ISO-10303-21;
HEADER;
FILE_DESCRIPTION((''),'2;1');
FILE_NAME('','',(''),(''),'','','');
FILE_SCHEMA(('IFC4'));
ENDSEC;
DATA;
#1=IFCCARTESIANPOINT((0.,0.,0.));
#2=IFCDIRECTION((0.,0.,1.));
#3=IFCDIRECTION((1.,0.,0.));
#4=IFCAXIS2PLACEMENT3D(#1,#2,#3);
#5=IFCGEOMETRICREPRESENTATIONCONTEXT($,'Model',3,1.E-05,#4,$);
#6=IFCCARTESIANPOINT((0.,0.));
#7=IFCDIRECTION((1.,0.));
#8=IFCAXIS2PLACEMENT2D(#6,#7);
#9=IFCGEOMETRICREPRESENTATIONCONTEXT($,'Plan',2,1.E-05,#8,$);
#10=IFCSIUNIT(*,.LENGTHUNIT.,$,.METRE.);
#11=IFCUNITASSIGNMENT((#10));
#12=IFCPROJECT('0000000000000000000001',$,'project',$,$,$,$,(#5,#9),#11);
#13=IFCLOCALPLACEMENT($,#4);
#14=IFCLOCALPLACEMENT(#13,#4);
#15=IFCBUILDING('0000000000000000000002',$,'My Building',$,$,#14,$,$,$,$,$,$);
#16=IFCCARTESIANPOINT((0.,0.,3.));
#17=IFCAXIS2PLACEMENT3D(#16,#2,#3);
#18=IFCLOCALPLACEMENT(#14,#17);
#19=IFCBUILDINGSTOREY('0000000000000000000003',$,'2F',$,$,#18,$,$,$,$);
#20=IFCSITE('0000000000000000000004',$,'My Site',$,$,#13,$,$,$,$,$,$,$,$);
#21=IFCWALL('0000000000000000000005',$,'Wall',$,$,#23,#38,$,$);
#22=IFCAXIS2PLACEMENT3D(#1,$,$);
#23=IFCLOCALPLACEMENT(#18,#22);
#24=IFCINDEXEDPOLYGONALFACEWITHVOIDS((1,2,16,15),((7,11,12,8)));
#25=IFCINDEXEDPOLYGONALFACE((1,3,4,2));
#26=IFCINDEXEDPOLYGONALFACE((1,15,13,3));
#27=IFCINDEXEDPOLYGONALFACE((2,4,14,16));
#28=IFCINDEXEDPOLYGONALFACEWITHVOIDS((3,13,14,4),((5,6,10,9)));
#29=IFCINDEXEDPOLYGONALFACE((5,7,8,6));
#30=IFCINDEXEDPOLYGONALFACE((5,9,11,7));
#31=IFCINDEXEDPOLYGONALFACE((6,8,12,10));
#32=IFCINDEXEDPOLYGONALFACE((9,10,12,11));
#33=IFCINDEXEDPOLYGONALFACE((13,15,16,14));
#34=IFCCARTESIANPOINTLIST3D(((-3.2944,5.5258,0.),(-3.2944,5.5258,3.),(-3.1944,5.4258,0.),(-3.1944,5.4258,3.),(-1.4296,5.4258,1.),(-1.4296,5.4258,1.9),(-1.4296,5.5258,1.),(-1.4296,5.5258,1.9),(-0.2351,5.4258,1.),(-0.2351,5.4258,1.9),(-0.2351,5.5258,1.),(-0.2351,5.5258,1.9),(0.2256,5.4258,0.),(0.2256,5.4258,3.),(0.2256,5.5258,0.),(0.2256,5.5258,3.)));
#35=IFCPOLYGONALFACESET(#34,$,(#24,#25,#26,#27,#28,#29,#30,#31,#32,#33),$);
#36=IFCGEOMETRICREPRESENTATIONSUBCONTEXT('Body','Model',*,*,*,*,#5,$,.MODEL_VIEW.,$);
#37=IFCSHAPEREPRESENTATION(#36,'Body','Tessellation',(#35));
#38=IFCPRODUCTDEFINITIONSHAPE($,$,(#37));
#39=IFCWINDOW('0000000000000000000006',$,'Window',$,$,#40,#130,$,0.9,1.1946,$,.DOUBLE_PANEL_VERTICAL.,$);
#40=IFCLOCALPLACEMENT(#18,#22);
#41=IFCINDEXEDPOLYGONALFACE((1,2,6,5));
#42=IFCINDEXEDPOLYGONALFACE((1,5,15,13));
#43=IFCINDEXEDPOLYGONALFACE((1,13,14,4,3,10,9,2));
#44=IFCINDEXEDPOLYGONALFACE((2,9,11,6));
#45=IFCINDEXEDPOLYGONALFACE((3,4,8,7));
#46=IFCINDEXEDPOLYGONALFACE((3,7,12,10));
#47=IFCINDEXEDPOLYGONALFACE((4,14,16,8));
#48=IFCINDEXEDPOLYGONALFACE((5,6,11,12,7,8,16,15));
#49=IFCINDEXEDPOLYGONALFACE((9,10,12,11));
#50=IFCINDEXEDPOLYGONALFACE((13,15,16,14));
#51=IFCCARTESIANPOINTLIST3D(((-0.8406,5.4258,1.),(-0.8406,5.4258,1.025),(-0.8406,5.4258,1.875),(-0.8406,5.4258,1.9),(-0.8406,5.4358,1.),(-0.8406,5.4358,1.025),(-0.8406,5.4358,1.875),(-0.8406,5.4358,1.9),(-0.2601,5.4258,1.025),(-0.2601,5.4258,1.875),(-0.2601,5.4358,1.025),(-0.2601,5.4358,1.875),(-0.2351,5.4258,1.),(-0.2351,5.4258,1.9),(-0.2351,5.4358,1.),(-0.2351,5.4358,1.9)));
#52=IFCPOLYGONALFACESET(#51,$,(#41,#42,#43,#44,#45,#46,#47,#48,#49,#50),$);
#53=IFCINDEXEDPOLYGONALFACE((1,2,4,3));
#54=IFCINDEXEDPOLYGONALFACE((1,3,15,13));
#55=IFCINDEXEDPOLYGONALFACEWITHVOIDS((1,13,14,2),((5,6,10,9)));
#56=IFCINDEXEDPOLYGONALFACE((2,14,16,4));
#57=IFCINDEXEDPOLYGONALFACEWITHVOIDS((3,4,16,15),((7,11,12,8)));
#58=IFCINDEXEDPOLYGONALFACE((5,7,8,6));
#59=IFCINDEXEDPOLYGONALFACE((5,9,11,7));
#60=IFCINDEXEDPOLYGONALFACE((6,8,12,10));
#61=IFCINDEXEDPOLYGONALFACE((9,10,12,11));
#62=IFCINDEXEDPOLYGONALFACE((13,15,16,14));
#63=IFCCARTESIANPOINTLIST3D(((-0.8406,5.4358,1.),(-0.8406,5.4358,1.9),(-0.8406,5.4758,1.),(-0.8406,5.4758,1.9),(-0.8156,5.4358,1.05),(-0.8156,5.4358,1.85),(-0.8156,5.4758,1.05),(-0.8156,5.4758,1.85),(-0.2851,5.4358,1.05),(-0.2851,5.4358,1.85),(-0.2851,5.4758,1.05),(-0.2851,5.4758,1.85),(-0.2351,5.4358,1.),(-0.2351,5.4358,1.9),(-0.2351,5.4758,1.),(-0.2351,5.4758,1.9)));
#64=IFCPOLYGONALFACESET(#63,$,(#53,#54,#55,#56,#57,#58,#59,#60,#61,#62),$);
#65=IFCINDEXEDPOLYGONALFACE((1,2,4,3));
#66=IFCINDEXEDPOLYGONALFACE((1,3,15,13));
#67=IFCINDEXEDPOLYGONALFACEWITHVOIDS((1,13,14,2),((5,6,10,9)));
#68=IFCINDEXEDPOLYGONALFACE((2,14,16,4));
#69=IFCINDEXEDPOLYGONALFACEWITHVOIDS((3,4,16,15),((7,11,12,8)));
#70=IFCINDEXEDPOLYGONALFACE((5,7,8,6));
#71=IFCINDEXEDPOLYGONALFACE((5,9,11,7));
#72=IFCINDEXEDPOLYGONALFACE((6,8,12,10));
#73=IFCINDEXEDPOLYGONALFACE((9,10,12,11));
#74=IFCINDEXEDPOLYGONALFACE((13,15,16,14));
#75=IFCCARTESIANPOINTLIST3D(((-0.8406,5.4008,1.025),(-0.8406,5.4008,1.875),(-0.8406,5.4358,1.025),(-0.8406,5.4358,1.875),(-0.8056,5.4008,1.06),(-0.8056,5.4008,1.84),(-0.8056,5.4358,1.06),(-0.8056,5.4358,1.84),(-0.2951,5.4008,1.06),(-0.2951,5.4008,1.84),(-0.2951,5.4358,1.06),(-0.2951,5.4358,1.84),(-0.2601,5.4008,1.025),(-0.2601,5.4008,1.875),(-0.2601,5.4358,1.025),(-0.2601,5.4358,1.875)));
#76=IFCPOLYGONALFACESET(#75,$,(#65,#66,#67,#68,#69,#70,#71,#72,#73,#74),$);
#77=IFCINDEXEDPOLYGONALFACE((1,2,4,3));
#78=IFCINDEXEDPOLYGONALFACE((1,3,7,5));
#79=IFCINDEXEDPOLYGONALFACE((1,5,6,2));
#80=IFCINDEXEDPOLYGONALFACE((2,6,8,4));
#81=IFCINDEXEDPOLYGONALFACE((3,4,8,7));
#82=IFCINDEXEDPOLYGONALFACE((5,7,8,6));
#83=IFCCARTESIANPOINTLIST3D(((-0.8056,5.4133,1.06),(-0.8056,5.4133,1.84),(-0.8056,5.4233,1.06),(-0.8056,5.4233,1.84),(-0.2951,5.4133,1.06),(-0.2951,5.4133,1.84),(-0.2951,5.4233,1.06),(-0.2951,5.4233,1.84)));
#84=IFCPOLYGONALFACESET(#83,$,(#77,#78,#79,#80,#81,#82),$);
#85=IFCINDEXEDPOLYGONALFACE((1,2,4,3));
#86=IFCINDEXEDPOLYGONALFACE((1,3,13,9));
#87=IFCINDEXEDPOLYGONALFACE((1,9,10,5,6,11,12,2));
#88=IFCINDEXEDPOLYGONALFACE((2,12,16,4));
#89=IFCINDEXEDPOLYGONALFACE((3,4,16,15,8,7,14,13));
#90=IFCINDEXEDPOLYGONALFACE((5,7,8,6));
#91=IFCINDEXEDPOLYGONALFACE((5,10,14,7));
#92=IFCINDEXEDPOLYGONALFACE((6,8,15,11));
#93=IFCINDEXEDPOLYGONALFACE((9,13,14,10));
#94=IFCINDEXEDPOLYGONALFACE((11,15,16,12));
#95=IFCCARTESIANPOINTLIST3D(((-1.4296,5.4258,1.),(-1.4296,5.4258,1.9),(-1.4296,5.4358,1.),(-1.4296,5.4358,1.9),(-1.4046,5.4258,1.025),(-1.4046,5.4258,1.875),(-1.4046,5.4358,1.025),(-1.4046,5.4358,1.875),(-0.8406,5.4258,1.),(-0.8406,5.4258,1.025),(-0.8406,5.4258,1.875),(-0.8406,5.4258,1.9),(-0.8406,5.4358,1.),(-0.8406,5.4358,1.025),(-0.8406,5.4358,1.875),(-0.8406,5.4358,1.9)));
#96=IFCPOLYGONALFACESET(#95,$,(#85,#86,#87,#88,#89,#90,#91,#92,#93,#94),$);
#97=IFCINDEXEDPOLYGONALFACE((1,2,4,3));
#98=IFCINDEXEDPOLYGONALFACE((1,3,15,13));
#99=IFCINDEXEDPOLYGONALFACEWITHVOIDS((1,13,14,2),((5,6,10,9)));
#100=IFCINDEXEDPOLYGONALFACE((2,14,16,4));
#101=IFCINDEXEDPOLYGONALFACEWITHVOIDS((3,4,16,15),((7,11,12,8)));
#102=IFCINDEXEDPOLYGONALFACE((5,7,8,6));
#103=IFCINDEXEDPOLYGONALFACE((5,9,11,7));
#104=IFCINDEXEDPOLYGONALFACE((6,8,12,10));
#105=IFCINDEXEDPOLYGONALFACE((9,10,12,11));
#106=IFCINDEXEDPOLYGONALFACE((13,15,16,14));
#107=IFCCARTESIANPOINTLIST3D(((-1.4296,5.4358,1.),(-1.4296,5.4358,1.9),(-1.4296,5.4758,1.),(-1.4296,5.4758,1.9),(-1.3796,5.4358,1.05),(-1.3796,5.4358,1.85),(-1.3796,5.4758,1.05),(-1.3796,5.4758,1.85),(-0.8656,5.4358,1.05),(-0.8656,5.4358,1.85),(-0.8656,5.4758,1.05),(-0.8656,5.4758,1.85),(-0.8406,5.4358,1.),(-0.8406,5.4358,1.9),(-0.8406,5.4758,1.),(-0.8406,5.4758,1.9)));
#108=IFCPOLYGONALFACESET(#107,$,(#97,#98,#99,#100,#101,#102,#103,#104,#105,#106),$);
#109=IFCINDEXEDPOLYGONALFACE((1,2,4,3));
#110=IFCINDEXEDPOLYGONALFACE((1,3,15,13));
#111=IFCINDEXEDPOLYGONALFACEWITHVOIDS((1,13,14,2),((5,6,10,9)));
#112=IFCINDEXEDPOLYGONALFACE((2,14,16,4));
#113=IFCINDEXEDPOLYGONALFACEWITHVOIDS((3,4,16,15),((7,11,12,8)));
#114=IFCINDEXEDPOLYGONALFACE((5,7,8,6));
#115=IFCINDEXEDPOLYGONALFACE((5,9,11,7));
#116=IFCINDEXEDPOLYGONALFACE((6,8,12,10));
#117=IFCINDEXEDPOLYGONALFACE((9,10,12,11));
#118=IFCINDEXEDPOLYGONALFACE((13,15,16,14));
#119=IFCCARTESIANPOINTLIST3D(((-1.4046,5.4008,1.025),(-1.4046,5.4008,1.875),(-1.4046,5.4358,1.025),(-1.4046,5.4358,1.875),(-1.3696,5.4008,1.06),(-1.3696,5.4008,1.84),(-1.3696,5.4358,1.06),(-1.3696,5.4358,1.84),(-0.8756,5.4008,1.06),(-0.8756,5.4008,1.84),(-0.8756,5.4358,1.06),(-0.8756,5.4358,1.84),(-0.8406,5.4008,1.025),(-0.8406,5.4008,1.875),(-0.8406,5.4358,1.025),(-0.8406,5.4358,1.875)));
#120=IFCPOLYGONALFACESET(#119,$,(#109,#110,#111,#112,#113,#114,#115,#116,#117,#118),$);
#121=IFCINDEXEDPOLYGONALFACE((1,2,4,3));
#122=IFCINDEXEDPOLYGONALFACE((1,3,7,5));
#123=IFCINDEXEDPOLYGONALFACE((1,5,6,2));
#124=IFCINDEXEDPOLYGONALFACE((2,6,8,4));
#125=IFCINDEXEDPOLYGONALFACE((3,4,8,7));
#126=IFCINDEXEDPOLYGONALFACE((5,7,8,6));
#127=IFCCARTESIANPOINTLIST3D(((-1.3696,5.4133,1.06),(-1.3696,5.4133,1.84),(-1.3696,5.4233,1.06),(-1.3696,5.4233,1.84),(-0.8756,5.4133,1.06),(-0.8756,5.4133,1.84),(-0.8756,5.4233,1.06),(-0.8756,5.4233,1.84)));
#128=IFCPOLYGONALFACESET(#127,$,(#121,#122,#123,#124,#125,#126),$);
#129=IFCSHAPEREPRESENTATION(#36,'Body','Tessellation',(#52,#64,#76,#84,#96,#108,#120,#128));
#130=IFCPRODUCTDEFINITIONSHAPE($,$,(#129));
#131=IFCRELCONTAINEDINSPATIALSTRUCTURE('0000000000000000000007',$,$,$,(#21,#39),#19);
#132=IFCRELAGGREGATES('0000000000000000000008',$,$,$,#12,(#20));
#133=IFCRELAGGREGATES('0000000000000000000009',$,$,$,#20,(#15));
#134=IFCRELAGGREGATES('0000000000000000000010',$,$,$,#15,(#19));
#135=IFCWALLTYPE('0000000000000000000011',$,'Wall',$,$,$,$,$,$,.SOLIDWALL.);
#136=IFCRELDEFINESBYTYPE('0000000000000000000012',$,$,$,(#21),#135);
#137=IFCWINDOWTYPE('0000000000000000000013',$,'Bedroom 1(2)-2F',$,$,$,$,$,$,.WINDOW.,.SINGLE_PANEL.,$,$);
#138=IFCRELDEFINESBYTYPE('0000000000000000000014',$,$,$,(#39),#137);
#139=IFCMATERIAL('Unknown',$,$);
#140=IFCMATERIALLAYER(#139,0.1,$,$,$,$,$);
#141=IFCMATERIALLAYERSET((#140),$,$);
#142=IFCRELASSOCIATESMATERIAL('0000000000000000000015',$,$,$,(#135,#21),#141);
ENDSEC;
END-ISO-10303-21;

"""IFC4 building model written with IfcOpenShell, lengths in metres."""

from ifc_helpers import new_model, entity, si_unit, frame, origin_with_axes, origin_2d_with_axis, place, context, subcontext, project, spatial, line, indexed_curve, outline, extrude, shape, source, transform, mapped, material, layer, layer_set, layer_usage, type_object, type_shapes, element, fill, save


model = new_model("IFC4")

# Units and contexts
model_context = context("Model", 3, precision=1e-05, world=origin_with_axes())
plan_context = context("Plan", 2, precision=1e-05, world=origin_2d_with_axis())
body_context_1 = subcontext(model_context, "Body", "Model", "MODEL_VIEW")
body_context_2 = subcontext(plan_context, "Body", "Plan", "PLAN_VIEW")
ifc_project = project(units=[si_unit("LENGTHUNIT", "METRE")], contexts=[model_context, plan_context])

# Site, building, storey
site_placement = place(None, origin_with_axes())
site = spatial("IfcSite", under=ifc_project, at=site_placement, Name="My Site")
building_placement = place(site_placement, origin_with_axes())
building = spatial("IfcBuilding", under=site, at=building_placement, Name="My Building")
storey_placement = place(building_placement, frame((0.0, 0.0, 3.0), z_axis=(0.0, 0.0, 1.0), x_axis=(1.0, 0.0, 0.0)))
storey = spatial("IfcBuildingStorey", under=building, at=storey_placement, Name="2F")

# Shared definitions
ifc_material = material(Name="Unknown")

# Shared definitions
ifc_layer_1 = layer(ifc_material, 0.1)
ifc_layer_set_1 = layer_set([ifc_layer_1])
wall_type = type_object("IfcWallType", Name="Wall", PredefinedType="SOLIDWALL", material=ifc_layer_set_1)

# Wall, opening, window
ifc_layer_usage_1 = layer_usage(ifc_layer_set_1, "AXIS2", "POSITIVE", 0.0)
wall_1_placement = place(storey_placement, frame((0.2256, 5.5258, 0.0), z_axis=(0.0, 0.0, 1.0), x_axis=(-1.0, 0.0, 0.0)))
wall_1 = element("IfcWall", 1, at=wall_1_placement, inside=storey, type_object=wall_type, material=ifc_layer_usage_1, Name="Wall", context=body_context_1, shape_type="SweptSolid", body=[
    extrude(outline(indexed_curve([(0.0, 0.0), (0.0, 0.1), (3.42, 0.1), (3.52, 0.0)], segments=[line(1, 2, 3, 4, 1)])), origin_with_axes(), (0.0, 0.0, 1.0), 3.0),
])
shared_shape_1 = source(origin_with_axes(), body_context_1, "Body", "SweptSolid", [
    extrude(outline(indexed_curve([(0.0, 0.0), (1.1946, 0.0), (1.1946, 0.9), (0.0, 0.9)], segments=[line(1, 2, 3, 4, 1)])), frame((0.0, -0.6, 0.0), z_axis=(0.0, -1.0, 0.0), x_axis=(1.0, 0.0, 0.0)), (0.0, 0.0, -1.0), 1.2),
])
opening_1_placement = place(wall_1_placement, frame((0.4607, 0.0, 1.0), z_axis=(0.0, 0.0, 1.0), x_axis=(1.0, 0.0, 0.0)))
opening_1 = element("IfcOpeningElement", 2, at=opening_1_placement, cuts=wall_1, PredefinedType="OPENING", context=body_context_1, shape_type="MappedRepresentation", body=[
    mapped(shared_shape_1, transform((0.0, 0.0, 0.0), x_axis=(1.0, 0.0, 0.0), y_axis=(0.0, 1.0, 0.0), z_axis=(0.0, 0.0, 1.0), scale=1.0)),
])
window_type_1 = type_object("IfcWindowType", Name="Bedroom 1(2)-2F", PartitioningType="SINGLE_PANEL", PredefinedType="WINDOW")
shared_shape_2 = source(origin_with_axes(), body_context_1, "Body", "SweptSolid", [
    extrude(outline(indexed_curve([(0.6056, 0.0), (0.0, 0.0), (0.0, 0.9), (0.6056, 0.9), (0.6056, 0.875), (0.025, 0.875), (0.025, 0.025), (0.6056, 0.025)], segments=[line(1, 2, 3, 4, 5, 6, 7, 8, 1)])), frame((0.0, 0.09, 0.0), z_axis=(0.0, -1.0, 0.0), x_axis=(1.0, 0.0, 0.0)), (0.0, 0.0, -1.0), 0.01),
    extrude(outline(indexed_curve([(0.0, 0.0), (0.6056, 0.0), (0.6056, 0.9), (0.0, 0.9)], segments=[line(1, 2, 3, 4, 1)]), holes=[indexed_curve([(0.05, 0.05), (0.5806, 0.05), (0.5806, 0.85), (0.05, 0.85)], segments=[line(1, 2, 3, 4, 1)])]), frame((0.0, 0.05, 0.0), z_axis=(0.0, -1.0, 0.0), x_axis=(1.0, 0.0, 0.0)), (0.0, 0.0, -1.0), 0.04),
    extrude(outline(indexed_curve([(0.0, 0.0), (0.5806, 0.0), (0.5806, 0.85), (0.0, 0.85)], segments=[line(1, 2, 3, 4, 1)]), holes=[indexed_curve([(0.035, 0.035), (0.5456, 0.035), (0.5456, 0.815), (0.035, 0.815)], segments=[line(1, 2, 3, 4, 1)])]), frame((0.025, 0.09, 0.025), z_axis=(0.0, -1.0, 0.0), x_axis=(1.0, 0.0, 0.0)), (0.0, 0.0, -1.0), 0.035),
    extrude(outline(indexed_curve([(0.035, 0.035), (0.5456, 0.035), (0.5456, 0.815), (0.035, 0.815)], segments=[line(1, 2, 3, 4, 1)])), frame((0.025, 0.1025, 0.025), z_axis=(0.0, -1.0, 0.0), x_axis=(1.0, 0.0, 0.0)), (0.0, 0.0, -1.0), 0.01),
    extrude(outline(indexed_curve([(0.0, 0.9), (0.589, 0.9), (0.589, 0.0), (0.0, 0.0), (0.0, 0.025), (0.564, 0.025), (0.564, 0.875), (0.0, 0.875)], segments=[line(1, 2, 3, 4, 5, 6, 7, 8, 1)])), frame((0.6056, 0.09, 0.0), z_axis=(0.0, -1.0, 0.0), x_axis=(1.0, 0.0, 0.0)), (0.0, 0.0, -1.0), 0.01),
    extrude(outline(indexed_curve([(0.0, 0.0), (0.589, 0.0), (0.589, 0.9), (0.0, 0.9)], segments=[line(1, 2, 3, 4, 1)]), holes=[indexed_curve([(0.025, 0.05), (0.539, 0.05), (0.539, 0.85), (0.025, 0.85)], segments=[line(1, 2, 3, 4, 1)])]), frame((0.6056, 0.05, 0.0), z_axis=(0.0, -1.0, 0.0), x_axis=(1.0, 0.0, 0.0)), (0.0, 0.0, -1.0), 0.04),
    extrude(outline(indexed_curve([(0.0, 0.0), (0.564, 0.0), (0.564, 0.85), (0.0, 0.85)], segments=[line(1, 2, 3, 4, 1)]), holes=[indexed_curve([(0.035, 0.035), (0.529, 0.035), (0.529, 0.815), (0.035, 0.815)], segments=[line(1, 2, 3, 4, 1)])]), frame((0.6056, 0.09, 0.025), z_axis=(0.0, -1.0, 0.0), x_axis=(1.0, 0.0, 0.0)), (0.0, 0.0, -1.0), 0.035),
    extrude(outline(indexed_curve([(0.035, 0.035), (0.529, 0.035), (0.529, 0.815), (0.035, 0.815)], segments=[line(1, 2, 3, 4, 1)])), frame((0.6056, 0.1025, 0.025), z_axis=(0.0, -1.0, 0.0), x_axis=(1.0, 0.0, 0.0)), (0.0, 0.0, -1.0), 0.01),
])
shared_shape_3 = source(origin_with_axes(), body_context_2, "Body", "Curve2D", [
    entity("IfcIndexedPolyCurve", entity("IfcCartesianPointList2D", [[0.05, 0.05], [0.5806, 0.05]])),
    entity("IfcIndexedPolyCurve", entity("IfcCartesianPointList2D", [[0.0, 0.1], [0.025, 0.1], [0.025, 0.09], [0.05, 0.09], [0.05, 0.05], [0.0, 0.05]]), [entity("IfcLineIndex", [1, 2, 3, 4, 5, 6, 1])]),
    entity("IfcIndexedPolyCurve", entity("IfcCartesianPointList2D", [[0.6056, 0.1], [0.6056, 0.1], [0.6056, 0.09], [0.5806, 0.09], [0.5806, 0.05], [0.6056, 0.05]])),
    entity("IfcIndexedPolyCurve", entity("IfcCartesianPointList2D", [[0.025, 0.09], [0.06, 0.09], [0.06, 0.125], [0.025, 0.125]]), [entity("IfcLineIndex", [1, 2, 3, 4, 1])]),
    entity("IfcIndexedPolyCurve", entity("IfcCartesianPointList2D", [[0.6056, 0.09], [0.5706, 0.09], [0.5706, 0.125], [0.6056, 0.125]]), [entity("IfcLineIndex", [1, 2, 3, 4, 1])]),
    entity("IfcIndexedPolyCurve", entity("IfcCartesianPointList2D", [[0.06, 0.09], [0.5706, 0.09]])),
    entity("IfcIndexedPolyCurve", entity("IfcCartesianPointList2D", [[0.06, 0.125], [0.5706, 0.125]])),
    entity("IfcIndexedPolyCurve", entity("IfcCartesianPointList2D", [[0.06, 0.1075], [0.5706, 0.1075]])),
    entity("IfcIndexedPolyCurve", entity("IfcCartesianPointList2D", [[0.6306, 0.05], [1.1446, 0.05]])),
    entity("IfcIndexedPolyCurve", entity("IfcCartesianPointList2D", [[0.6056, 0.1], [0.6056, 0.1], [0.6056, 0.09], [0.6306, 0.09], [0.6306, 0.05], [0.6056, 0.05]])),
    entity("IfcIndexedPolyCurve", entity("IfcCartesianPointList2D", [[1.1946, 0.1], [1.1696, 0.1], [1.1696, 0.09], [1.1446, 0.09], [1.1446, 0.05], [1.1946, 0.05]]), [entity("IfcLineIndex", [1, 2, 3, 4, 5, 6, 1])]),
    entity("IfcIndexedPolyCurve", entity("IfcCartesianPointList2D", [[0.6056, 0.09], [0.6406, 0.09], [0.6406, 0.125], [0.6056, 0.125]]), [entity("IfcLineIndex", [1, 2, 3, 4, 1])]),
    entity("IfcIndexedPolyCurve", entity("IfcCartesianPointList2D", [[1.1696, 0.09], [1.1346, 0.09], [1.1346, 0.125], [1.1696, 0.125]]), [entity("IfcLineIndex", [1, 2, 3, 4, 1])]),
    entity("IfcIndexedPolyCurve", entity("IfcCartesianPointList2D", [[0.6406, 0.09], [1.1346, 0.09]])),
    entity("IfcIndexedPolyCurve", entity("IfcCartesianPointList2D", [[0.6406, 0.125], [1.1346, 0.125]])),
    entity("IfcIndexedPolyCurve", entity("IfcCartesianPointList2D", [[0.6406, 0.1075], [1.1346, 0.1075]])),
])
type_shapes(window_type_1, [shared_shape_2, shared_shape_3])
window_1_placement = place(opening_1_placement, frame((0.0, 0.0, 0.0), z_axis=(0.0, 0.0, 1.0), x_axis=(1.0, 0.0, 0.0)))
window_1 = element("IfcWindow", 3, at=window_1_placement, inside=storey, type_object=window_type_1, Name="Window", OverallHeight=0.9, OverallWidth=1.1946, PartitioningType="DOUBLE_PANEL_VERTICAL", shapes=[
    shape(body_context_1, "Body", "MappedRepresentation", [mapped(shared_shape_2, transform((0.0, 0.0, 0.0), x_axis=(1.0, 0.0, 0.0), y_axis=(0.0, 1.0, 0.0), z_axis=(0.0, 0.0, 1.0), scale=1.0))]),
    shape(body_context_2, "Body", "MappedRepresentation", [mapped(shared_shape_3, transform((0.0, 0.0, 0.0), x_axis=(1.0, 0.0, 0.0), y_axis=(0.0, 1.0, 0.0), z_axis=(0.0, 0.0, 1.0), scale=1.0))]),
])
fill(opening_1, window_1)

save(model, "model.ifc")
